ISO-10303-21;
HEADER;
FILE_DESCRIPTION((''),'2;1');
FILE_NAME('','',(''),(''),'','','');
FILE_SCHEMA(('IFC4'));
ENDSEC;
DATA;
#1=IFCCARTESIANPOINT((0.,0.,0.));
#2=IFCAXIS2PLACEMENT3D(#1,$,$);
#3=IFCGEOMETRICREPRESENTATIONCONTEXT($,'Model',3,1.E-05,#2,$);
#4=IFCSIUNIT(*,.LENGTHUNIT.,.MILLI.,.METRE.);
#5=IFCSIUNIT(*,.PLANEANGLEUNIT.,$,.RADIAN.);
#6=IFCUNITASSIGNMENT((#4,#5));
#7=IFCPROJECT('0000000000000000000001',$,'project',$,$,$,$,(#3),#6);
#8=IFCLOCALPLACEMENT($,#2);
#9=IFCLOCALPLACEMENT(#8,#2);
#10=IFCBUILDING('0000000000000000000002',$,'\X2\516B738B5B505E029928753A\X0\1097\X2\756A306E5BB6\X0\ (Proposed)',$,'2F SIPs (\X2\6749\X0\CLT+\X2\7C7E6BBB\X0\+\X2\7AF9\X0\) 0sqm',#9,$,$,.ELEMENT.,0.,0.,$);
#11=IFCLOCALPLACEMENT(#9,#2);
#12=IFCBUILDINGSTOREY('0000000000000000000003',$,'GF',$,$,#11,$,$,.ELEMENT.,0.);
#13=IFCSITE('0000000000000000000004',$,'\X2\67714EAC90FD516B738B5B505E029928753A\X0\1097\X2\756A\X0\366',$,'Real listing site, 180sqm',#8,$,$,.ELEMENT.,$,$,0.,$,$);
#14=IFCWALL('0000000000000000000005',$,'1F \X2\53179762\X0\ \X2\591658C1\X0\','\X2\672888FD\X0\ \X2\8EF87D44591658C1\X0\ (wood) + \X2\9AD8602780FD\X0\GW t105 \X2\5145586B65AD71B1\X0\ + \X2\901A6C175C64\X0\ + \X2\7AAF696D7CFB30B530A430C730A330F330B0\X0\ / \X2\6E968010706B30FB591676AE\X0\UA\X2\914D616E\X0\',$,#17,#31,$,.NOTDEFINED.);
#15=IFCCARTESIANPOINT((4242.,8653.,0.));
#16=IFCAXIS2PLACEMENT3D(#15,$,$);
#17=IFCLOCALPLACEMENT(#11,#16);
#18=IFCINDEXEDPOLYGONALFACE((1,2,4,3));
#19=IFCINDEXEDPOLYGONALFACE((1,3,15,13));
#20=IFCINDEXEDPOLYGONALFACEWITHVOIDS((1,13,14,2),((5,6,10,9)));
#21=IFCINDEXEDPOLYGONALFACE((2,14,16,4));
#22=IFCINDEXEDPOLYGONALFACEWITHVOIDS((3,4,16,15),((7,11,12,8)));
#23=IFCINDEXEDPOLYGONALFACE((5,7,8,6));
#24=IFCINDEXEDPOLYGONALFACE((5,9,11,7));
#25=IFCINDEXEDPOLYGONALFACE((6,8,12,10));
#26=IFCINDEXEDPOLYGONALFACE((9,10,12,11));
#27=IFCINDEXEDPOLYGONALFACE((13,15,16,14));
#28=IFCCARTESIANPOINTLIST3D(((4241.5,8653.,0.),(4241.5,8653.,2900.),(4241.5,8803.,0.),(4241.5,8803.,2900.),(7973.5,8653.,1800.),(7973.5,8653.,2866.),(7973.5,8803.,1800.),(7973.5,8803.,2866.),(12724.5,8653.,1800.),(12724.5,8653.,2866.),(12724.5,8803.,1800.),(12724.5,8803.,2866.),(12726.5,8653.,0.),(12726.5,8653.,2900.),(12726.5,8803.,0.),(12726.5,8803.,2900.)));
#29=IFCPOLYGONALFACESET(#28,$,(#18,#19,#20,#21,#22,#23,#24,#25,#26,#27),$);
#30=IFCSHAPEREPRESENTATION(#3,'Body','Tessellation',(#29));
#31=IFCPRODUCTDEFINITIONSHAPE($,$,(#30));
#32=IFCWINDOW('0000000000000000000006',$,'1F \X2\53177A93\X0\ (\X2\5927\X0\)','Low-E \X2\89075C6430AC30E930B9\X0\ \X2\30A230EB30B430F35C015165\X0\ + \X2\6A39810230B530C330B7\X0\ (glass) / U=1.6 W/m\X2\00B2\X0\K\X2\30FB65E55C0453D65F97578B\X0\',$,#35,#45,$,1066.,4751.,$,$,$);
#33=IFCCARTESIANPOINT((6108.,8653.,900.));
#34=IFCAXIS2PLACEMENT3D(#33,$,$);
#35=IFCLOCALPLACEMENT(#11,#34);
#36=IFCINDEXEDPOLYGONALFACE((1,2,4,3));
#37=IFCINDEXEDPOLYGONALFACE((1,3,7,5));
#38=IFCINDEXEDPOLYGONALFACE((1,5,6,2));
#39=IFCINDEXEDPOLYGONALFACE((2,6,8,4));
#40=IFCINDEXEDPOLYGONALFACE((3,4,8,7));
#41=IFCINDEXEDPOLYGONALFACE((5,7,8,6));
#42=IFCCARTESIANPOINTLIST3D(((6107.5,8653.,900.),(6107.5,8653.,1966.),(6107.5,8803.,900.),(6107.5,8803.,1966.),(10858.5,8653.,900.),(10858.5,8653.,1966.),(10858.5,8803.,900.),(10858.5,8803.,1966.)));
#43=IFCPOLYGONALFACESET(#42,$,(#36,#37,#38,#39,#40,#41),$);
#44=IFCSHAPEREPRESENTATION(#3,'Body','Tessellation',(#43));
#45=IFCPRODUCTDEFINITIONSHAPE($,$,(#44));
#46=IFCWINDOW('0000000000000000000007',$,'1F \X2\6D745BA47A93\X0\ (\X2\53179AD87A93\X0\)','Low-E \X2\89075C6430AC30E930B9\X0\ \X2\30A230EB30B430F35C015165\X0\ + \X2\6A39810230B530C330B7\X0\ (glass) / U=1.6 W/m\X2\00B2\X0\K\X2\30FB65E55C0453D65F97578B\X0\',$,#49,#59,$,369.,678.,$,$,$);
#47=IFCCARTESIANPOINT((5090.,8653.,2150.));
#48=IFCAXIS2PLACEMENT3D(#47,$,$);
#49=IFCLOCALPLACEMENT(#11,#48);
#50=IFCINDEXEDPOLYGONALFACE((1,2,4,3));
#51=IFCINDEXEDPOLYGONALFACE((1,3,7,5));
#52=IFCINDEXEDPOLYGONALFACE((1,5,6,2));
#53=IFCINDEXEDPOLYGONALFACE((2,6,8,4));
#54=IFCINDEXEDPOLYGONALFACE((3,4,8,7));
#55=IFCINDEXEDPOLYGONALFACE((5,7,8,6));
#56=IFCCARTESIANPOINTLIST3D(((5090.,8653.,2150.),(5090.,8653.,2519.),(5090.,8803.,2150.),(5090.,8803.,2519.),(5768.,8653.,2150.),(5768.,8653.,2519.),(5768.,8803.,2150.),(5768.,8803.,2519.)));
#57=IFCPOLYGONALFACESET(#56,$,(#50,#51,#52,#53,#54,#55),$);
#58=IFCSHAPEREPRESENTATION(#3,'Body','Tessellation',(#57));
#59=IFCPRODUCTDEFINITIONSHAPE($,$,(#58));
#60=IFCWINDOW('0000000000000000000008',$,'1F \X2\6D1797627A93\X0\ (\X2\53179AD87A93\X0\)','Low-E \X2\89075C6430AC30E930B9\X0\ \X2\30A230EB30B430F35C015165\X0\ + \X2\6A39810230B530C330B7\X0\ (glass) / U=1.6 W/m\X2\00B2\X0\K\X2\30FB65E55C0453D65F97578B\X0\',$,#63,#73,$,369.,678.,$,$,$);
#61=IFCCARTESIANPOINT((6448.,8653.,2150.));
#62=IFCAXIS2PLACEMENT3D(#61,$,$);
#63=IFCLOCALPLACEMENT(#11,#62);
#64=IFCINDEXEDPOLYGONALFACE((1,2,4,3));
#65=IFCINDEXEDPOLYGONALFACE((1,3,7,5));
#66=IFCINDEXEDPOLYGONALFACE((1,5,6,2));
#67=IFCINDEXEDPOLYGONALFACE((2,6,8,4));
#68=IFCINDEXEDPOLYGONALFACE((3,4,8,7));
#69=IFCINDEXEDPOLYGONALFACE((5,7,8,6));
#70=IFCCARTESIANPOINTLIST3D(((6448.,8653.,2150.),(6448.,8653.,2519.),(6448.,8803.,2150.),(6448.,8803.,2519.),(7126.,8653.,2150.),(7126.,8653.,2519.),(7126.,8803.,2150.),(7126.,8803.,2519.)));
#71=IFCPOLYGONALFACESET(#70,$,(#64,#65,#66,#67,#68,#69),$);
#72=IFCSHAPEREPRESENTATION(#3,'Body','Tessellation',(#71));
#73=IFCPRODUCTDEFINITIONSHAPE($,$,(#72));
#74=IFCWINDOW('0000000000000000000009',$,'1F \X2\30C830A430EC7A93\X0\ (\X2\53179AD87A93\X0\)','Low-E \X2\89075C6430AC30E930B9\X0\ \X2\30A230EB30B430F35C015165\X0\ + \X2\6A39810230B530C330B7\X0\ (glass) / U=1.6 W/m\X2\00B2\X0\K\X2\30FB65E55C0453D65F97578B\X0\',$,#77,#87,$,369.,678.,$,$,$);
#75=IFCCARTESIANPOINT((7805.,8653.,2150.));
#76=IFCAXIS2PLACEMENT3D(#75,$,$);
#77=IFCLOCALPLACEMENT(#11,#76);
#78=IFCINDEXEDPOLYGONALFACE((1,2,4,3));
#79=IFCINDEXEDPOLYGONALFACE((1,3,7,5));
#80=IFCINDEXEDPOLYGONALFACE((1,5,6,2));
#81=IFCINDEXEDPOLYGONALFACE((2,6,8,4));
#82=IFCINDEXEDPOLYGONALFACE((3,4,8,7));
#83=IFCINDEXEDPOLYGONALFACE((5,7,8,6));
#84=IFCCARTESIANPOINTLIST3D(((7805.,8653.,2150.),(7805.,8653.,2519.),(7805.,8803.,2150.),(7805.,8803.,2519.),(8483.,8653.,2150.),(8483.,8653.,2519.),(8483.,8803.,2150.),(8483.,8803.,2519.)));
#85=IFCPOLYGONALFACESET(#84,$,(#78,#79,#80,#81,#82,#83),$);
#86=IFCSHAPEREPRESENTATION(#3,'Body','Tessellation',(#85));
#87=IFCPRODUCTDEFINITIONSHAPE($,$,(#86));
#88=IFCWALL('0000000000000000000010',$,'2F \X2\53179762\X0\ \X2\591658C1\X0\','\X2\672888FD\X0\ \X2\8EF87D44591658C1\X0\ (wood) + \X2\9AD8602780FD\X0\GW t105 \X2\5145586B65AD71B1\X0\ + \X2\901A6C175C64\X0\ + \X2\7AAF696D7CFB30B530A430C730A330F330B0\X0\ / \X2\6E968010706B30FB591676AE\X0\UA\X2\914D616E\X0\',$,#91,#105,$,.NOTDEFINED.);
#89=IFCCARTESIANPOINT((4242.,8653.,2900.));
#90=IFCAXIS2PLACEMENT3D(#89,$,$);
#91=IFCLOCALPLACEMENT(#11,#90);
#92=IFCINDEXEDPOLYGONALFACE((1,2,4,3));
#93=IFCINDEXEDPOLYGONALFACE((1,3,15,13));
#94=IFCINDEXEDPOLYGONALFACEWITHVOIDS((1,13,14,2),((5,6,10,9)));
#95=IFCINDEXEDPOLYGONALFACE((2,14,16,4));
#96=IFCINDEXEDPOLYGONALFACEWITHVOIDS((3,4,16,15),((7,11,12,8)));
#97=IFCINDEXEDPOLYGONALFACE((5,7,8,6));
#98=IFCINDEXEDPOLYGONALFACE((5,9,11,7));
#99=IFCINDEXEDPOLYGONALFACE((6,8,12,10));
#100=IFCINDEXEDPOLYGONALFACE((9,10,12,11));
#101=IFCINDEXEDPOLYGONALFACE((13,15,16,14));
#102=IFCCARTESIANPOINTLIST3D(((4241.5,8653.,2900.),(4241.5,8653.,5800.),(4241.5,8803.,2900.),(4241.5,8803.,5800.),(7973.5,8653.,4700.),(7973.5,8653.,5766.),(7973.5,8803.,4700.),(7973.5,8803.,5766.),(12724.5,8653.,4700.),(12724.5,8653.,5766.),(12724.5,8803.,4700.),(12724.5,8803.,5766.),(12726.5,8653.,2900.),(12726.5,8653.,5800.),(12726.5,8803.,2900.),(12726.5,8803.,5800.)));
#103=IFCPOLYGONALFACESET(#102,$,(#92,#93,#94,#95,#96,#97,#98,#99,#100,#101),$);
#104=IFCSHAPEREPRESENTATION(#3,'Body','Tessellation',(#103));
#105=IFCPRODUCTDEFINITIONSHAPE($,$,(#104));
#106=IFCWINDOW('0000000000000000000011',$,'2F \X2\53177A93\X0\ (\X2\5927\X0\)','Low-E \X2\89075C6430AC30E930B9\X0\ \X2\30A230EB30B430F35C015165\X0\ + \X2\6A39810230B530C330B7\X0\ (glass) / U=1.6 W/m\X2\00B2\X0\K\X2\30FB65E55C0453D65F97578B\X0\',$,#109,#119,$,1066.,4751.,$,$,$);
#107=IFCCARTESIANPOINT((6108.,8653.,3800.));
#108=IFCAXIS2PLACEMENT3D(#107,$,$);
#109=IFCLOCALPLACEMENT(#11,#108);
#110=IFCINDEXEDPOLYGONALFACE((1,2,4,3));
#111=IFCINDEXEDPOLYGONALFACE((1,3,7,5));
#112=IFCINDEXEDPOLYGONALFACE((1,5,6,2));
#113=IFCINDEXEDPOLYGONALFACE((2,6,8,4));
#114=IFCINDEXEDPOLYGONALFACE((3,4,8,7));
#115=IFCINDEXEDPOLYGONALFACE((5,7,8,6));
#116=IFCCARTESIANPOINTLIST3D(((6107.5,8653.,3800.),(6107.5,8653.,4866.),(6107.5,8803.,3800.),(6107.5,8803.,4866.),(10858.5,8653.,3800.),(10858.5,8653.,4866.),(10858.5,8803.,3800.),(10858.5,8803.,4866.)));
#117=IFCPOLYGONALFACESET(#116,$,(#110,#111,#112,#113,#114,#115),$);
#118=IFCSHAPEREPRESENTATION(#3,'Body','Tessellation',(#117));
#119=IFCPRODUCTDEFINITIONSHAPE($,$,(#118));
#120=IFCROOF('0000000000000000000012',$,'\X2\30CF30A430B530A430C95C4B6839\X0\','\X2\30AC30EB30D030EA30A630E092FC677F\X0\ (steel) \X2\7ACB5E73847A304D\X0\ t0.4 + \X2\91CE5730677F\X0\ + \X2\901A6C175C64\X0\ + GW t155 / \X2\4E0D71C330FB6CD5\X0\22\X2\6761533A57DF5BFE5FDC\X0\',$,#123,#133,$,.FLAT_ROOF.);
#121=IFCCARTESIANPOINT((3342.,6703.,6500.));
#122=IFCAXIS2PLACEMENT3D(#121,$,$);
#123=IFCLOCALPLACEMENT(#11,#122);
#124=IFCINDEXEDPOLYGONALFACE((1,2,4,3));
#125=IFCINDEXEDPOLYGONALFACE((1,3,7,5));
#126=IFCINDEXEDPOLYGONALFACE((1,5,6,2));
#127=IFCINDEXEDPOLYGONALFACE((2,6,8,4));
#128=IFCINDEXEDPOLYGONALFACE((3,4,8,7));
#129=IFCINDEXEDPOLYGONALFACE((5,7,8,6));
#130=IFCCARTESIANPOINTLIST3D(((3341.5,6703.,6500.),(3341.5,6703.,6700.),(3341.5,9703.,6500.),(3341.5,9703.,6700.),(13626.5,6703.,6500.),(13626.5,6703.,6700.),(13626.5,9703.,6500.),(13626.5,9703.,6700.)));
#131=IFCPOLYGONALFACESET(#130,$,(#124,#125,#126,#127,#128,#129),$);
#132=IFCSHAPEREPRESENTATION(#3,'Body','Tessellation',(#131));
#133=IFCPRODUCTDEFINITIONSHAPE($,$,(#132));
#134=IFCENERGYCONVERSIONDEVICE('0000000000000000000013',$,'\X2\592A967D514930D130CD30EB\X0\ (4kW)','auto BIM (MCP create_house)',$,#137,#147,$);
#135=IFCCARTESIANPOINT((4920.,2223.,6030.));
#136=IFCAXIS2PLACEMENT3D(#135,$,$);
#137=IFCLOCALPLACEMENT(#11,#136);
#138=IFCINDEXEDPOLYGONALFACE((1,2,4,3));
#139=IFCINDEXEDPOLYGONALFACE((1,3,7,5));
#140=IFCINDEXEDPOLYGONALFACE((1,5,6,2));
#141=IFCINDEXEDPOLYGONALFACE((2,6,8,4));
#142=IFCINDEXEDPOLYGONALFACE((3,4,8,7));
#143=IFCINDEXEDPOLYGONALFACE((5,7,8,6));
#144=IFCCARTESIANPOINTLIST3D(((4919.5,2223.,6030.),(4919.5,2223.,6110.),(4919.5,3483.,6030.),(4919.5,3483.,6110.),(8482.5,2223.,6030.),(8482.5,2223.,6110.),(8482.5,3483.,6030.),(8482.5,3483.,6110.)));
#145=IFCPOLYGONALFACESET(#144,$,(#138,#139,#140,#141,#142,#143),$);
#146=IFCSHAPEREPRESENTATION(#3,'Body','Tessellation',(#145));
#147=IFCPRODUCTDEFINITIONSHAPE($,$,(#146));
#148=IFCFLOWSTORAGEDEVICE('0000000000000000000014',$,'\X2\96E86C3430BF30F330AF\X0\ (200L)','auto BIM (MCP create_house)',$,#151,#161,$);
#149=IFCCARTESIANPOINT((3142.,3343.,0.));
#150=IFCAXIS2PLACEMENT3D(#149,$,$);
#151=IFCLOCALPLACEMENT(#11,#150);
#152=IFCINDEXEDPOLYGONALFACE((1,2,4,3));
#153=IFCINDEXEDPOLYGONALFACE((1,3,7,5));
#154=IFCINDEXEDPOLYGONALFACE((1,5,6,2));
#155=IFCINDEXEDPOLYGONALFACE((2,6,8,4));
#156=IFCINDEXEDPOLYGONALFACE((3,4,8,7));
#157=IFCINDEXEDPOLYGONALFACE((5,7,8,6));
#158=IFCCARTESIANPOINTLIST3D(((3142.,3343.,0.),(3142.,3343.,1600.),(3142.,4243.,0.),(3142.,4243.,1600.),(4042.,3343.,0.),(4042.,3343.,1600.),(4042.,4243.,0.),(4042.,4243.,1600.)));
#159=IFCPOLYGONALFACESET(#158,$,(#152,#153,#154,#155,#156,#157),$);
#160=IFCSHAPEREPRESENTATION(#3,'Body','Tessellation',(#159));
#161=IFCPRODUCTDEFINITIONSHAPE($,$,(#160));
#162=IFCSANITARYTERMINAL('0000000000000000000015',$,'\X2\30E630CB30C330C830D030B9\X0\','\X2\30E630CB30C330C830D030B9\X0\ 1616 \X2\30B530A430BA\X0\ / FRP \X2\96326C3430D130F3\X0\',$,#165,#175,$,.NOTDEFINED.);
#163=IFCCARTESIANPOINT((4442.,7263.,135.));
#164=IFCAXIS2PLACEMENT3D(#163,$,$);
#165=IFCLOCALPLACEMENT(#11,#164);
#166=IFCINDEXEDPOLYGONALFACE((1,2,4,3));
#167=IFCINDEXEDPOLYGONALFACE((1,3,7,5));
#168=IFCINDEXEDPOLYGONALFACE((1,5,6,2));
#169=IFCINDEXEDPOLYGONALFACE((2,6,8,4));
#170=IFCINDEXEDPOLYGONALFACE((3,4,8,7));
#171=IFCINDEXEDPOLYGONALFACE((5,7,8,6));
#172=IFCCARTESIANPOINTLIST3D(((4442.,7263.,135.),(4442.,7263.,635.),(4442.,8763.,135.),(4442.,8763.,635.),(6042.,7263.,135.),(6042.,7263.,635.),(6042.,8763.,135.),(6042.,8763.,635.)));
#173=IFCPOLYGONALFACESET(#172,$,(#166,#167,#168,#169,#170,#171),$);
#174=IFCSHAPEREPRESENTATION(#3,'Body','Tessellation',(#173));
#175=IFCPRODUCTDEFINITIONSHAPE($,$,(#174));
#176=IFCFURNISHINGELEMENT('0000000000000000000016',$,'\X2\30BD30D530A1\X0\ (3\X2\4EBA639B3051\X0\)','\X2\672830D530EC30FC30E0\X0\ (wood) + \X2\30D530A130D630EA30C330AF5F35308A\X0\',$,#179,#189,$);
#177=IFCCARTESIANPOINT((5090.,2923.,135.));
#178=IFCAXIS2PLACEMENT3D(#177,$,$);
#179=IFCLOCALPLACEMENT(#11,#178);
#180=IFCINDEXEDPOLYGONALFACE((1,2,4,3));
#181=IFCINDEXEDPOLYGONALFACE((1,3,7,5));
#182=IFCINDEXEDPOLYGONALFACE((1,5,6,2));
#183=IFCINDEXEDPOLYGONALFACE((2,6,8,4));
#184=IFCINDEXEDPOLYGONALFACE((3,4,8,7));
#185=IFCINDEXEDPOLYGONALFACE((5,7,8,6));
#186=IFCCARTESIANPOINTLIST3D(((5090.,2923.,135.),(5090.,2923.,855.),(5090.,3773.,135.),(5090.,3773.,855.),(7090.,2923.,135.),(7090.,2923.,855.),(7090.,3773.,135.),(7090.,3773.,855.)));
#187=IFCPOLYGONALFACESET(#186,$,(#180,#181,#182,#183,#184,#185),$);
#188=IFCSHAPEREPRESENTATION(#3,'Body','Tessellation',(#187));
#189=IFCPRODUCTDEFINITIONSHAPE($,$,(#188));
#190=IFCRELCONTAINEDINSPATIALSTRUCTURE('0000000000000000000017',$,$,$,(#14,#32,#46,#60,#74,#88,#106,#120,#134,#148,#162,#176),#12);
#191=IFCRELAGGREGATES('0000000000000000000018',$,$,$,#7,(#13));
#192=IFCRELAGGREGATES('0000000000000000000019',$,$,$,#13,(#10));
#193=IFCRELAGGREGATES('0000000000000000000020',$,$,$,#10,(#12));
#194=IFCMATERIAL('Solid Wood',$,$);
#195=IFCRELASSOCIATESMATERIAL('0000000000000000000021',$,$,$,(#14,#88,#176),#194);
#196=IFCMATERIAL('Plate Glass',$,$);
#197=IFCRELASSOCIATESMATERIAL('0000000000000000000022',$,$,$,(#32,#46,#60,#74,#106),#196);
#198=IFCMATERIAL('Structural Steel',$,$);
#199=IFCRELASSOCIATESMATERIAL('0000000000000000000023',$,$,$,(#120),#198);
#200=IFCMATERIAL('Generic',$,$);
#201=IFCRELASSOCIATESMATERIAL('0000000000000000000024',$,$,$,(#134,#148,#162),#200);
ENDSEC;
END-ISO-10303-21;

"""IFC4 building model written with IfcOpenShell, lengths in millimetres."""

from ifc_helpers import new_model, si_unit, frame, frame_2d, origin, place, context, project, spatial, rectangle, extrude, material, element, fill, save


model = new_model("IFC4")

# Units and contexts
model_context = context("Model", 3, precision=1e-05, world=origin())
ifc_project = project(units=[si_unit("LENGTHUNIT", "METRE", prefix="MILLI"), si_unit("PLANEANGLEUNIT", "RADIAN")], contexts=[model_context])

# Site, building, storey
site_placement = place(None, origin())
site = spatial("IfcSite", under=ifc_project, at=site_placement, Name="東京都八王子市館町1097番366", ObjectType="Real listing site, 180sqm", CompositionType="ELEMENT", RefElevation=0.0)
building_placement = place(site_placement, origin())
building = spatial("IfcBuilding", under=site, at=building_placement, Name="八王子市館町1097番の家 (Proposed)", ObjectType="2F SIPs (杉CLT+籾殻+竹) 0sqm", CompositionType="ELEMENT", ElevationOfRefHeight=0.0, ElevationOfTerrain=0.0)
storey_placement = place(building_placement, origin())
storey = spatial("IfcBuildingStorey", under=building, at=storey_placement, Name="GF", CompositionType="ELEMENT", Elevation=0.0)

# Wall, openings, windows
ifc_material_1 = material(Name="Solid Wood")
wall_1_placement = place(storey_placement, frame((4242.0, 8653.0, 0.0)))
wall_1 = element("IfcWall", 1, at=wall_1_placement, inside=storey, material=ifc_material_1, Name="1F 北面 外壁", Description="木製 軸組外壁 (wood) + 高性能GW t105 充填断熱 + 通気層 + 窯業系サイディング / 準耐火・外皮UA配慮", PredefinedType="NOTDEFINED", context=model_context, shape_type="SweptSolid", body=[
    extrude(rectangle(XDim=8485.0, YDim=150.0, at=frame_2d((4242.0, 75.0))), frame((4242.0, 8653.0, 0.0)), (0.0, 0.0, 1.0), 2900.0),
])
opening_1_placement = place(storey_placement, frame((6108.0, 8653.0, 900.0)))
opening_1 = element("IfcOpeningElement", 2, at=opening_1_placement, cuts=wall_1, PredefinedType="NOTDEFINED", context=model_context, shape_type="SweptSolid", body=[
    extrude(rectangle(XDim=4751.0, YDim=150.0, at=frame_2d((2375.0, 75.0))), frame((6108.0, 8653.0, 900.0)), (0.0, 0.0, 1.0), 1066.0),
])
opening_2_placement = place(storey_placement, frame((5090.0, 8653.0, 2150.0)))
opening_2 = element("IfcOpeningElement", 3, at=opening_2_placement, cuts=wall_1, PredefinedType="NOTDEFINED", context=model_context, shape_type="SweptSolid", body=[
    extrude(rectangle(XDim=678.0, YDim=150.0, at=frame_2d((339.0, 75.0))), frame((5090.0, 8653.0, 2150.0)), (0.0, 0.0, 1.0), 369.0),
])
opening_3_placement = place(storey_placement, frame((6448.0, 8653.0, 2150.0)))
opening_3 = element("IfcOpeningElement", 4, at=opening_3_placement, cuts=wall_1, PredefinedType="NOTDEFINED", context=model_context, shape_type="SweptSolid", body=[
    extrude(rectangle(XDim=678.0, YDim=150.0, at=frame_2d((339.0, 75.0))), frame((6448.0, 8653.0, 2150.0)), (0.0, 0.0, 1.0), 369.0),
])
opening_4_placement = place(storey_placement, frame((7805.0, 8653.0, 2150.0)))
opening_4 = element("IfcOpeningElement", 5, at=opening_4_placement, cuts=wall_1, PredefinedType="NOTDEFINED", context=model_context, shape_type="SweptSolid", body=[
    extrude(rectangle(XDim=678.0, YDim=150.0, at=frame_2d((339.0, 75.0))), frame((7805.0, 8653.0, 2150.0)), (0.0, 0.0, 1.0), 369.0),
])
ifc_material_2 = material(Name="Plate Glass")
window_1_placement = place(storey_placement, frame((6108.0, 8653.0, 900.0)))
window_1 = element("IfcWindow", 6, at=window_1_placement, inside=storey, material=ifc_material_2, Name="1F 北窓 (大)", Description="Low-E 複層ガラス アルゴン封入 + 樹脂サッシ (glass) / U=1.6 W/m²K・日射取得型", OverallHeight=1066.0, OverallWidth=4751.0, context=model_context, shape_type="SweptSolid", body=[
    extrude(rectangle(XDim=4751.0, YDim=150.0, at=frame_2d((2375.0, 75.0))), frame((6108.0, 8653.0, 900.0)), (0.0, 0.0, 1.0), 1066.0),
])
fill(opening_1, window_1)
window_2_placement = place(storey_placement, frame((5090.0, 8653.0, 2150.0)))
window_2 = element("IfcWindow", 7, at=window_2_placement, inside=storey, material=ifc_material_2, Name="1F 浴室窓 (北高窓)", Description="Low-E 複層ガラス アルゴン封入 + 樹脂サッシ (glass) / U=1.6 W/m²K・日射取得型", OverallHeight=369.0, OverallWidth=678.0, context=model_context, shape_type="SweptSolid", body=[
    extrude(rectangle(XDim=678.0, YDim=150.0, at=frame_2d((339.0, 75.0))), frame((5090.0, 8653.0, 2150.0)), (0.0, 0.0, 1.0), 369.0),
])
fill(opening_2, window_2)
window_3_placement = place(storey_placement, frame((6448.0, 8653.0, 2150.0)))
window_3 = element("IfcWindow", 8, at=window_3_placement, inside=storey, material=ifc_material_2, Name="1F 洗面窓 (北高窓)", Description="Low-E 複層ガラス アルゴン封入 + 樹脂サッシ (glass) / U=1.6 W/m²K・日射取得型", OverallHeight=369.0, OverallWidth=678.0, context=model_context, shape_type="SweptSolid", body=[
    extrude(rectangle(XDim=678.0, YDim=150.0, at=frame_2d((339.0, 75.0))), frame((6448.0, 8653.0, 2150.0)), (0.0, 0.0, 1.0), 369.0),
])
fill(opening_3, window_3)
window_4_placement = place(storey_placement, frame((7805.0, 8653.0, 2150.0)))
window_4 = element("IfcWindow", 9, at=window_4_placement, inside=storey, material=ifc_material_2, Name="1F トイレ窓 (北高窓)", Description="Low-E 複層ガラス アルゴン封入 + 樹脂サッシ (glass) / U=1.6 W/m²K・日射取得型", OverallHeight=369.0, OverallWidth=678.0, context=model_context, shape_type="SweptSolid", body=[
    extrude(rectangle(XDim=678.0, YDim=150.0, at=frame_2d((339.0, 75.0))), frame((7805.0, 8653.0, 2150.0)), (0.0, 0.0, 1.0), 369.0),
])
fill(opening_4, window_4)

# Wall, opening, window
wall_2_placement = place(storey_placement, frame((4242.0, 8653.0, 2900.0)))
wall_2 = element("IfcWall", 10, at=wall_2_placement, inside=storey, material=ifc_material_1, Name="2F 北面 外壁", Description="木製 軸組外壁 (wood) + 高性能GW t105 充填断熱 + 通気層 + 窯業系サイディング / 準耐火・外皮UA配慮", PredefinedType="NOTDEFINED", context=model_context, shape_type="SweptSolid", body=[
    extrude(rectangle(XDim=8485.0, YDim=150.0, at=frame_2d((4242.0, 75.0))), frame((4242.0, 8653.0, 2900.0)), (0.0, 0.0, 1.0), 2900.0),
])
opening_5_placement = place(storey_placement, frame((6108.0, 8653.0, 3800.0)))
opening_5 = element("IfcOpeningElement", 11, at=opening_5_placement, cuts=wall_2, PredefinedType="NOTDEFINED", context=model_context, shape_type="SweptSolid", body=[
    extrude(rectangle(XDim=4751.0, YDim=150.0, at=frame_2d((2375.0, 75.0))), frame((6108.0, 8653.0, 3800.0)), (0.0, 0.0, 1.0), 1066.0),
])
window_5_placement = place(storey_placement, frame((6108.0, 8653.0, 3800.0)))
window_5 = element("IfcWindow", 12, at=window_5_placement, inside=storey, material=ifc_material_2, Name="2F 北窓 (大)", Description="Low-E 複層ガラス アルゴン封入 + 樹脂サッシ (glass) / U=1.6 W/m²K・日射取得型", OverallHeight=1066.0, OverallWidth=4751.0, context=model_context, shape_type="SweptSolid", body=[
    extrude(rectangle(XDim=4751.0, YDim=150.0, at=frame_2d((2375.0, 75.0))), frame((6108.0, 8653.0, 3800.0)), (0.0, 0.0, 1.0), 1066.0),
])
fill(opening_5, window_5)

# Roof
ifc_material_3 = material(Name="Structural Steel")
roof_placement = place(storey_placement, frame((3342.0, 6703.0, 6500.0)))
element("IfcRoof", 13, at=roof_placement, inside=storey, material=ifc_material_3, Name="ハイサイド屋根", Description="ガルバリウム鋼板 (steel) 立平葺き t0.4 + 野地板 + 通気層 + GW t155 / 不燃・法22条区域対応", PredefinedType="FLAT_ROOF", context=model_context, shape_type="SweptSolid", body=[
    extrude(rectangle(XDim=10285.0, YDim=3000.0, at=frame_2d((5142.0, 1500.0))), frame((3342.0, 6703.0, 6500.0)), (0.0, 0.0, 1.0), 200.0),
])

# Energy conversion device
ifc_material_4 = material(Name="Generic")
energy_conversion_device_placement = place(storey_placement, frame((4920.0, 2223.0, 6030.0)))
element("IfcEnergyConversionDevice", 14, at=energy_conversion_device_placement, inside=storey, material=ifc_material_4, Name="太陽光パネル (4kW)", Description="auto BIM (MCP create_house)", context=model_context, shape_type="SweptSolid", body=[
    extrude(rectangle(XDim=3563.0, YDim=1260.0, at=frame_2d((1781.0, 630.0))), frame((4920.0, 2223.0, 6030.0)), (0.0, 0.0, 1.0), 80.0),
])

# Flow storage device
flow_storage_device_placement = place(storey_placement, frame((3142.0, 3343.0, 0.0)))
element("IfcFlowStorageDevice", 15, at=flow_storage_device_placement, inside=storey, material=ifc_material_4, Name="雨水タンク (200L)", Description="auto BIM (MCP create_house)", context=model_context, shape_type="SweptSolid", body=[
    extrude(rectangle(XDim=900.0, YDim=900.0, at=frame_2d((450.0, 450.0))), frame((3142.0, 3343.0, 0.0)), (0.0, 0.0, 1.0), 1600.0),
])

# Sanitary terminal
sanitary_terminal_placement = place(storey_placement, frame((4442.0, 7263.0, 135.0)))
element("IfcSanitaryTerminal", 16, at=sanitary_terminal_placement, inside=storey, material=ifc_material_4, Name="ユニットバス", Description="ユニットバス 1616 サイズ / FRP 防水パン", PredefinedType="NOTDEFINED", context=model_context, shape_type="SweptSolid", body=[
    extrude(rectangle(XDim=1600.0, YDim=1500.0, at=frame_2d((800.0, 750.0))), frame((4442.0, 7263.0, 135.0)), (0.0, 0.0, 1.0), 500.0),
])

# Furnishing element
furnishing_1_placement = place(storey_placement, frame((5090.0, 2923.0, 135.0)))
element("IfcFurnishingElement", 17, at=furnishing_1_placement, inside=storey, material=ifc_material_1, Name="ソファ (3人掛け)", Description="木フレーム (wood) + ファブリック張り", context=model_context, shape_type="SweptSolid", body=[
    extrude(rectangle(XDim=2000.0, YDim=850.0, at=frame_2d((1000.0, 425.0))), frame((5090.0, 2923.0, 135.0)), (0.0, 0.0, 1.0), 720.0),
])

save(model, "model.ifc")
